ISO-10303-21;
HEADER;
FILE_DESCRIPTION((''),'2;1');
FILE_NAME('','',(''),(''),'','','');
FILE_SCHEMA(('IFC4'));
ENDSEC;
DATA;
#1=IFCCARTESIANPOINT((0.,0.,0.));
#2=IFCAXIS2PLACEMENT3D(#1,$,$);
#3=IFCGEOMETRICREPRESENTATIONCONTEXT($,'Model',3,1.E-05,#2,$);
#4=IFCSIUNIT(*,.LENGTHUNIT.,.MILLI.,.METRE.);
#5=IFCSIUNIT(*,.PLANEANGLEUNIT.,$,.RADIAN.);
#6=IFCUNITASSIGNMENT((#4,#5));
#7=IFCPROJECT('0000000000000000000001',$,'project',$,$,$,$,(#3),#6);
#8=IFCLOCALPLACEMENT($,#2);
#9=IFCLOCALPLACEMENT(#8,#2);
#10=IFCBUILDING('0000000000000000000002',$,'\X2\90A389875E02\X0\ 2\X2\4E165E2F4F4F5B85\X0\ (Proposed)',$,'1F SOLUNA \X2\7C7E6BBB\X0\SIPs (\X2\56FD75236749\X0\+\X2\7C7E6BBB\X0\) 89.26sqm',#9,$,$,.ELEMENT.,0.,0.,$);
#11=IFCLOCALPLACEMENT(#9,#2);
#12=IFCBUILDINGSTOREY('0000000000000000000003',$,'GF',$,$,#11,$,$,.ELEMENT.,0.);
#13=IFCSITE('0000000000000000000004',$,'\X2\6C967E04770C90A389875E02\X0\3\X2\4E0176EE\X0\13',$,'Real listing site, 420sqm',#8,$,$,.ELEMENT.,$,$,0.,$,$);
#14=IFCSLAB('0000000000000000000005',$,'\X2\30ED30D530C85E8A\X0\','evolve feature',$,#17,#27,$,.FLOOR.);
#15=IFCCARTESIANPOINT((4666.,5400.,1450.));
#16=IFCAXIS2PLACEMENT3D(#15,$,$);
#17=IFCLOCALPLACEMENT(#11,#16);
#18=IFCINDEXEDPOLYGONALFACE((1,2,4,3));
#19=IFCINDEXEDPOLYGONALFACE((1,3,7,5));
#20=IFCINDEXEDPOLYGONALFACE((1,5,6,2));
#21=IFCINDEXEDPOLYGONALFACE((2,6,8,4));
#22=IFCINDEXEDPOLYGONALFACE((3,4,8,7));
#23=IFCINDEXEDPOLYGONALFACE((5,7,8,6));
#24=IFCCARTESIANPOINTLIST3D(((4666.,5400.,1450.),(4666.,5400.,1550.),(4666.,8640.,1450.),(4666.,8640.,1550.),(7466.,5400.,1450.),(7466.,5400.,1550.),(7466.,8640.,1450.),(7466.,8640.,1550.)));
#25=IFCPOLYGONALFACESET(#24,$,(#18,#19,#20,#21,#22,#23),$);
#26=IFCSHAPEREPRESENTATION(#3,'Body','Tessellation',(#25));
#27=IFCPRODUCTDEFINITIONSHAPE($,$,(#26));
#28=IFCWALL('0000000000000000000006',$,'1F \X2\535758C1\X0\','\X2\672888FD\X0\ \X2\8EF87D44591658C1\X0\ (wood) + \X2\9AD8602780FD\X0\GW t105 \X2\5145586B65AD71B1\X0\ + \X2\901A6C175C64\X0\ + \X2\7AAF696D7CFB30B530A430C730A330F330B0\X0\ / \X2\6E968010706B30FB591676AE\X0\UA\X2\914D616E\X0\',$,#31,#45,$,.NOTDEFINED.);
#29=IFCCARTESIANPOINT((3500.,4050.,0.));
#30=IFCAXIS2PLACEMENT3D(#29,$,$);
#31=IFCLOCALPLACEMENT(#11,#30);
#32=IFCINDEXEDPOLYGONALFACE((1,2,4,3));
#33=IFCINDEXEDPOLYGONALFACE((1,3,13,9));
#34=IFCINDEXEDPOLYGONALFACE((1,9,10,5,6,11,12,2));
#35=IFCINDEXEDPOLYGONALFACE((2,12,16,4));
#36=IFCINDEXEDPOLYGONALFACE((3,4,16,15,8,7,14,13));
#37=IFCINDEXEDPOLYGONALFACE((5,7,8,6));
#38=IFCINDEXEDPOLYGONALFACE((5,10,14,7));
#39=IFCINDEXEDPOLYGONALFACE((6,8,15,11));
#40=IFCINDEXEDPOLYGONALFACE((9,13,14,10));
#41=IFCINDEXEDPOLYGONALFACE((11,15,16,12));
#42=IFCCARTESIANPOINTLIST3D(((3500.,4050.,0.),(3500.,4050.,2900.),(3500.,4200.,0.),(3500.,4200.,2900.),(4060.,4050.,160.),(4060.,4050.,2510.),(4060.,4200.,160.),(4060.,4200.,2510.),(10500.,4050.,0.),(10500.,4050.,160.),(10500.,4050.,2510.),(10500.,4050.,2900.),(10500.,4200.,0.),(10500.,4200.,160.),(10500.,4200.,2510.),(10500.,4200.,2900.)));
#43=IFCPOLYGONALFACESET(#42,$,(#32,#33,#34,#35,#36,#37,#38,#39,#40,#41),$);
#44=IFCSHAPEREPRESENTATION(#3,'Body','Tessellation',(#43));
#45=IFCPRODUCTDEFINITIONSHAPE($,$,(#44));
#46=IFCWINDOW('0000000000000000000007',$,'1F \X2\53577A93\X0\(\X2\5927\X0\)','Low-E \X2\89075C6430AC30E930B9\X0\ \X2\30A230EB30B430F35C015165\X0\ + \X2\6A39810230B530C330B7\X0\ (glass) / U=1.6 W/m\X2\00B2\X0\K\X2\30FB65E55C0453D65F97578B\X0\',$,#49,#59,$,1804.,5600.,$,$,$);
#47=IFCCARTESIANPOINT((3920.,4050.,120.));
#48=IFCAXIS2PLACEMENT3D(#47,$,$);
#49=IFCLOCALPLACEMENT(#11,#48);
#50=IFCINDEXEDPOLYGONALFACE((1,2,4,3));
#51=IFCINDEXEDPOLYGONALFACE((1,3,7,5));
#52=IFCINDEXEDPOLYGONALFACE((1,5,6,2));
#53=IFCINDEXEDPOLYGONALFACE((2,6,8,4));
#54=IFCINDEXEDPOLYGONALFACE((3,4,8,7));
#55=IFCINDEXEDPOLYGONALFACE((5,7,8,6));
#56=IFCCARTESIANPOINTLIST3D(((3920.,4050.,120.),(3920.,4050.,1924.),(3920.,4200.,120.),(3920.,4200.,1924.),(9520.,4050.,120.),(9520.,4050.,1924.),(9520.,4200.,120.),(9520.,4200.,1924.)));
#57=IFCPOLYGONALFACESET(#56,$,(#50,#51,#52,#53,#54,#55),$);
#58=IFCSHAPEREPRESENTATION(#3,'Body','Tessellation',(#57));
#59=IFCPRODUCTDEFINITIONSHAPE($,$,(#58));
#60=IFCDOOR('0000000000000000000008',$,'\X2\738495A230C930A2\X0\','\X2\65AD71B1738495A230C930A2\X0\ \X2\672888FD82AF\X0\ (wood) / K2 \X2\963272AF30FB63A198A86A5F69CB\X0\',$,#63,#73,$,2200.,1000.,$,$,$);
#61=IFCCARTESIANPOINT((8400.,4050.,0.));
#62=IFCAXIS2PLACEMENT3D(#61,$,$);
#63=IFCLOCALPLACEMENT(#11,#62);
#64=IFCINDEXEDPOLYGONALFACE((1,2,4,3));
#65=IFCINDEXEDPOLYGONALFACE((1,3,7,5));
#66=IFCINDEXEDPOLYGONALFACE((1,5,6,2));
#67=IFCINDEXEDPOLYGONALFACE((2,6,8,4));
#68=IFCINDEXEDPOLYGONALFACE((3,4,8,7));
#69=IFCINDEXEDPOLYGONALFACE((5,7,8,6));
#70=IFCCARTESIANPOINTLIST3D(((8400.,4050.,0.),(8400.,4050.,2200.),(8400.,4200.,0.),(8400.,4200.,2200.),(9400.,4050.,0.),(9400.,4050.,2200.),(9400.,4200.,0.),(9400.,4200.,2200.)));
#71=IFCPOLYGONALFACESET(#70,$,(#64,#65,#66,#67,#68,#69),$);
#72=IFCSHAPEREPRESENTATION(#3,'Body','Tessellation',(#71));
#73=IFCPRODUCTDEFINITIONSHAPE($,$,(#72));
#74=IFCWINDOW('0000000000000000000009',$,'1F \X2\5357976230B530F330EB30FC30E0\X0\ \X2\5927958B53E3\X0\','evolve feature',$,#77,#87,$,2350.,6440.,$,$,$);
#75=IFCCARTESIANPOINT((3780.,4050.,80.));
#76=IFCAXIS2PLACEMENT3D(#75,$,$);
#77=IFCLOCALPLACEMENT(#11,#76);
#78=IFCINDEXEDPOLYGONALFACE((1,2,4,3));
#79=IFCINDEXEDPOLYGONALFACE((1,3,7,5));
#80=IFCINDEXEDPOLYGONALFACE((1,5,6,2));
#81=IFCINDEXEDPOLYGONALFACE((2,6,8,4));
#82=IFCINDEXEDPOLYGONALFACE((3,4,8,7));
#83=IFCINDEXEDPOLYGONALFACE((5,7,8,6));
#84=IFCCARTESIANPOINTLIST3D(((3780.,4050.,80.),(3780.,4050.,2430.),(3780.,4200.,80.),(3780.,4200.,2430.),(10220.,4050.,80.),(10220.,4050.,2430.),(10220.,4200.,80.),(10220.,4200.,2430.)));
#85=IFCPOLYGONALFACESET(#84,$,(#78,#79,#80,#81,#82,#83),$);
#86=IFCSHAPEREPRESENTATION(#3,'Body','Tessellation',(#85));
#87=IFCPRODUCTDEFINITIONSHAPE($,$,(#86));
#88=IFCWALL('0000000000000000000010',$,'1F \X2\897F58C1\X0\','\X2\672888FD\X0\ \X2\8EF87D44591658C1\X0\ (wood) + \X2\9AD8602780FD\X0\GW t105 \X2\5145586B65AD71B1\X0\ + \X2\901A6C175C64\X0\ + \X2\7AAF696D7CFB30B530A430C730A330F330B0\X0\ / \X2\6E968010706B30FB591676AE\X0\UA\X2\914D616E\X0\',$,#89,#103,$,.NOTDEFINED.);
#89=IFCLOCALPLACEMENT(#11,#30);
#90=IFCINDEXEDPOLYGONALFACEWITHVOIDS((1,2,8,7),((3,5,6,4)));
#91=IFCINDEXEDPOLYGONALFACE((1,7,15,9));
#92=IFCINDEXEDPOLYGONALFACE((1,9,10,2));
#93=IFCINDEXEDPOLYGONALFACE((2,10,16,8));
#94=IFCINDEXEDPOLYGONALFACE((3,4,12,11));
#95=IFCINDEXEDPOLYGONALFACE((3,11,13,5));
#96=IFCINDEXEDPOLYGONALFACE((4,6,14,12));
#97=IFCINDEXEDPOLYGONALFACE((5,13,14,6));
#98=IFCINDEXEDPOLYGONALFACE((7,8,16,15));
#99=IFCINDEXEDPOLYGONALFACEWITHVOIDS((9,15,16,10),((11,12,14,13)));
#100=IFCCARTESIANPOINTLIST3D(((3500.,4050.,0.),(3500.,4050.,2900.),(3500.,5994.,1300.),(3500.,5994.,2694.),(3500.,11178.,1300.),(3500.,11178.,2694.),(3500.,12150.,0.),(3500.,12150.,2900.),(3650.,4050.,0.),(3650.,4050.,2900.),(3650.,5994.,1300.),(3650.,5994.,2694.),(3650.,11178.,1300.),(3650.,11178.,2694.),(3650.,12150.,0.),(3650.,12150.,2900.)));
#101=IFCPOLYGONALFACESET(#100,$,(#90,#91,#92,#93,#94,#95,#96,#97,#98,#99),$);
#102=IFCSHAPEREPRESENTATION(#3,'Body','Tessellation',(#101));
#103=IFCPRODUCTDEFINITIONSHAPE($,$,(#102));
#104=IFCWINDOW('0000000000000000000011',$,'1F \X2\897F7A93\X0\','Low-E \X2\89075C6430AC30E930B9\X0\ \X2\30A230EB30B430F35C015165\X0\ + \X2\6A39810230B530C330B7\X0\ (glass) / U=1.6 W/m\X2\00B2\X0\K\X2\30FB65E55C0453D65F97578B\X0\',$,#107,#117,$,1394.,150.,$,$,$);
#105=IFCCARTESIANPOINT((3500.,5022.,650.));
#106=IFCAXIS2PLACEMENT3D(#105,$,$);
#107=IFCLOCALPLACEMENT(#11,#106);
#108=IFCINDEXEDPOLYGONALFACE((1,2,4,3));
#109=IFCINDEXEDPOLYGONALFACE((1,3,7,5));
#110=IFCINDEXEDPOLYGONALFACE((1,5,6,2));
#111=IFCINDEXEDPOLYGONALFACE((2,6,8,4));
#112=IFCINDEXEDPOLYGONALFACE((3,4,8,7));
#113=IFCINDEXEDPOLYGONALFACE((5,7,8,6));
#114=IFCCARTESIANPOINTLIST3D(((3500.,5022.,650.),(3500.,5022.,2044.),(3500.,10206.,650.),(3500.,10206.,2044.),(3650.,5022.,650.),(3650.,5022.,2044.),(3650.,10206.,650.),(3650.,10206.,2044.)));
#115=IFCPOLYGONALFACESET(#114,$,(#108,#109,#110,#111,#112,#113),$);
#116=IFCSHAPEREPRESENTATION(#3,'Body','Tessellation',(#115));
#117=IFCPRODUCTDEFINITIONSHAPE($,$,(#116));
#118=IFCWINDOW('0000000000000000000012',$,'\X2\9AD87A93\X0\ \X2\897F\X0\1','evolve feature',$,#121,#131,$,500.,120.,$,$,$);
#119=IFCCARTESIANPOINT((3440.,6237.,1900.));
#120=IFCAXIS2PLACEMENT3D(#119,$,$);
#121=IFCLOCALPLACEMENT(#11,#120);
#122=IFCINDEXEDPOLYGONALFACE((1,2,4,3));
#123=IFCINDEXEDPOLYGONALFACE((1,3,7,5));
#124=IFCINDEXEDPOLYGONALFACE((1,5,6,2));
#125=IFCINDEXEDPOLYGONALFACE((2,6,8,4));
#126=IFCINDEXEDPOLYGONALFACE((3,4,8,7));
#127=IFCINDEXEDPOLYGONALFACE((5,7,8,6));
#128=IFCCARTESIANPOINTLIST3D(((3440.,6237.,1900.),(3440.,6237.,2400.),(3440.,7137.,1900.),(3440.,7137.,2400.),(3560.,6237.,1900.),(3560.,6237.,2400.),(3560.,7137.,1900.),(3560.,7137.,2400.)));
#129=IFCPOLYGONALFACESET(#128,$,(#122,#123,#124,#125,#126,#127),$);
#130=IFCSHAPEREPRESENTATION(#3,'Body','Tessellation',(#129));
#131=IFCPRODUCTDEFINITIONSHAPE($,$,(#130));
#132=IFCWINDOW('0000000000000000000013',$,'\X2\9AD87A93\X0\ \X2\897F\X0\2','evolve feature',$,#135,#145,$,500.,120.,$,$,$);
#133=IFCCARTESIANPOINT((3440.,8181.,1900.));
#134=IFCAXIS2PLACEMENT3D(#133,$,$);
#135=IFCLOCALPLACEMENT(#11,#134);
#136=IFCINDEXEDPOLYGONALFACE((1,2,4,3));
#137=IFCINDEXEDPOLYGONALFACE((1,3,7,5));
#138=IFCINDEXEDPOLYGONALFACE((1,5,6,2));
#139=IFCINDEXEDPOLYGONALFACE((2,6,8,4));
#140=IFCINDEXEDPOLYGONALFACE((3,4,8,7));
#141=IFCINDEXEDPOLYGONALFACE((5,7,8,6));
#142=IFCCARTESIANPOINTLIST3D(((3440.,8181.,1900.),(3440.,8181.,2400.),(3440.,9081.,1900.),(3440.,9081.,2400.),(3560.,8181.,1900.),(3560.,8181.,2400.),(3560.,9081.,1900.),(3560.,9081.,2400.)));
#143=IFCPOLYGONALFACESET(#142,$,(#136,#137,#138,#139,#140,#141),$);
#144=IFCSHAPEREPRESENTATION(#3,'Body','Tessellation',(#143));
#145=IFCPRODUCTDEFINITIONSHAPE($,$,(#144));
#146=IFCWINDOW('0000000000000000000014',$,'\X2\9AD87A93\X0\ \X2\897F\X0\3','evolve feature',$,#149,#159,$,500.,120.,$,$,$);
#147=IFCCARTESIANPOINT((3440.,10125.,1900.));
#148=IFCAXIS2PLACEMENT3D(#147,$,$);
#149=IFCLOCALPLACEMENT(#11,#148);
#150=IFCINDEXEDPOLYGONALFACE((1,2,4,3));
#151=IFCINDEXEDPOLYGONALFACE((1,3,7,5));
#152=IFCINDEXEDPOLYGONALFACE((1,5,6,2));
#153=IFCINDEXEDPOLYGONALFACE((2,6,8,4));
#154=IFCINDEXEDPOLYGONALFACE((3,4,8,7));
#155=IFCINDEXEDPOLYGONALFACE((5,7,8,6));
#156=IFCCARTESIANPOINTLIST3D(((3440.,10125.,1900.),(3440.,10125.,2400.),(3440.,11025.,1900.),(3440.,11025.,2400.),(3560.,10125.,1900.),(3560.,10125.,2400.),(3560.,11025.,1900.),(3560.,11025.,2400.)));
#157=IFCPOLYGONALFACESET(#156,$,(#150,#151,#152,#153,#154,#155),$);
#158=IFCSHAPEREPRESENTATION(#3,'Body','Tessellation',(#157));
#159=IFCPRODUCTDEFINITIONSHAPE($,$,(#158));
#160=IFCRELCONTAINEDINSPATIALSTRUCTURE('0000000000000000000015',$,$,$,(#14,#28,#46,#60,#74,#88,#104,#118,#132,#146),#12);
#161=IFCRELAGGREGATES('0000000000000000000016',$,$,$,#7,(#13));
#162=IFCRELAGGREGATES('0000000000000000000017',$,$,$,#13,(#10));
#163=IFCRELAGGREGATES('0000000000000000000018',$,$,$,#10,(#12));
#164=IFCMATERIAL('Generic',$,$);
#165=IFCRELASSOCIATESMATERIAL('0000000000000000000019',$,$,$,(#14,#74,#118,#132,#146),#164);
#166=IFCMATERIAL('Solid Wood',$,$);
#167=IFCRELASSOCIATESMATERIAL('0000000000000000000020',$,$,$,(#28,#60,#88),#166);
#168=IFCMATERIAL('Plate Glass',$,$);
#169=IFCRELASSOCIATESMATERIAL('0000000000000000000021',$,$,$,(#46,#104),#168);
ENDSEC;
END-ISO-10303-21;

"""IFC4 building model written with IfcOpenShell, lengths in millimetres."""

from ifc_helpers import new_model, si_unit, frame, frame_2d, origin, place, context, project, spatial, rectangle, extrude, material, element, fill, save


model = new_model("IFC4")

# Units and contexts
model_context = context("Model", 3, precision=1e-05, world=origin())
ifc_project = project(units=[si_unit("LENGTHUNIT", "METRE", prefix="MILLI"), si_unit("PLANEANGLEUNIT", "RADIAN")], contexts=[model_context])

# Site, building, storey
site_placement = place(None, origin())
site = spatial("IfcSite", under=ifc_project, at=site_placement, Name="沖縄県那覇市3丁目13", ObjectType="Real listing site, 420sqm", CompositionType="ELEMENT", RefElevation=0.0)
building_placement = place(site_placement, origin())
building = spatial("IfcBuilding", under=site, at=building_placement, Name="那覇市 2世帯住宅 (Proposed)", ObjectType="1F SOLUNA 籾殻SIPs (国産杉+籾殻) 89.26sqm", CompositionType="ELEMENT", ElevationOfRefHeight=0.0, ElevationOfTerrain=0.0)
storey_placement = place(building_placement, origin())
storey = spatial("IfcBuildingStorey", under=building, at=storey_placement, Name="GF", CompositionType="ELEMENT", Elevation=0.0)

# Slab
ifc_material_1 = material(Name="Solid Wood")
ifc_material_2 = material(Name="Generic")
slab_1_placement = place(storey_placement, frame((4666.0, 5400.0, 1450.0)))
element("IfcSlab", 1, at=slab_1_placement, inside=storey, material=ifc_material_2, Name="ロフト床", Description="evolve feature", PredefinedType="FLOOR", context=model_context, shape_type="SweptSolid", body=[
    extrude(rectangle(XDim=2800.0, YDim=3240.0, at=frame_2d((1400.0, 1620.0))), frame((4666.0, 5400.0, 1450.0)), (0.0, 0.0, 1.0), 100.0),
])

# Wall, openings, windows, door
wall_1_placement = place(storey_placement, frame((3500.0, 4050.0, 0.0)))
wall_1 = element("IfcWall", 2, at=wall_1_placement, inside=storey, material=ifc_material_1, Name="1F 南壁", Description="木製 軸組外壁 (wood) + 高性能GW t105 充填断熱 + 通気層 + 窯業系サイディング / 準耐火・外皮UA配慮", PredefinedType="NOTDEFINED", context=model_context, shape_type="SweptSolid", body=[
    extrude(rectangle(XDim=7000.0, YDim=150.0, at=frame_2d((3500.0, 75.0))), frame((3500.0, 4050.0, 0.0)), (0.0, 0.0, 1.0), 2900.0),
])
opening_1_placement = place(storey_placement, frame((3920.0, 4050.0, 120.0)))
opening_1 = element("IfcOpeningElement", 3, at=opening_1_placement, cuts=wall_1, PredefinedType="NOTDEFINED", context=model_context, shape_type="SweptSolid", body=[
    extrude(rectangle(XDim=5600.0, YDim=150.0, at=frame_2d((2800.0, 75.0))), frame((3920.0, 4050.0, 120.0)), (0.0, 0.0, 1.0), 1804.0),
])
opening_2_placement = place(storey_placement, frame((8400.0, 4050.0, 0.0)))
opening_2 = element("IfcOpeningElement", 4, at=opening_2_placement, cuts=wall_1, PredefinedType="NOTDEFINED", context=model_context, shape_type="SweptSolid", body=[
    extrude(rectangle(XDim=1000.0, YDim=150.0, at=frame_2d((500.0, 75.0))), frame((8400.0, 4050.0, 0.0)), (0.0, 0.0, 1.0), 2200.0),
])
opening_3_placement = place(storey_placement, frame((3780.0, 4050.0, 80.0)))
opening_3 = element("IfcOpeningElement", 5, at=opening_3_placement, cuts=wall_1, PredefinedType="NOTDEFINED", context=model_context, shape_type="SweptSolid", body=[
    extrude(rectangle(XDim=6440.0, YDim=150.0, at=frame_2d((3220.0, 75.0))), frame((3780.0, 4050.0, 80.0)), (0.0, 0.0, 1.0), 2350.0),
])
ifc_material_3 = material(Name="Plate Glass")
window_1_placement = place(storey_placement, frame((3920.0, 4050.0, 120.0)))
window_1 = element("IfcWindow", 6, at=window_1_placement, inside=storey, material=ifc_material_3, Name="1F 南窓(大)", Description="Low-E 複層ガラス アルゴン封入 + 樹脂サッシ (glass) / U=1.6 W/m²K・日射取得型", OverallHeight=1804.0, OverallWidth=5600.0, context=model_context, shape_type="SweptSolid", body=[
    extrude(rectangle(XDim=5600.0, YDim=150.0, at=frame_2d((2800.0, 75.0))), frame((3920.0, 4050.0, 120.0)), (0.0, 0.0, 1.0), 1804.0),
])
fill(opening_1, window_1)
door_placement = place(storey_placement, frame((8400.0, 4050.0, 0.0)))
door = element("IfcDoor", 7, at=door_placement, inside=storey, material=ifc_material_1, Name="玄関ドア", Description="断熱玄関ドア 木製芯 (wood) / K2 防犯・採風機構", OverallHeight=2200.0, OverallWidth=1000.0, context=model_context, shape_type="SweptSolid", body=[
    extrude(rectangle(XDim=1000.0, YDim=150.0, at=frame_2d((500.0, 75.0))), frame((8400.0, 4050.0, 0.0)), (0.0, 0.0, 1.0), 2200.0),
])
fill(opening_2, door)
window_2_placement = place(storey_placement, frame((3780.0, 4050.0, 80.0)))
window_2 = element("IfcWindow", 8, at=window_2_placement, inside=storey, material=ifc_material_2, Name="1F 南面サンルーム 大開口", Description="evolve feature", OverallHeight=2350.0, OverallWidth=6440.0, context=model_context, shape_type="SweptSolid", body=[
    extrude(rectangle(XDim=6440.0, YDim=150.0, at=frame_2d((3220.0, 75.0))), frame((3780.0, 4050.0, 80.0)), (0.0, 0.0, 1.0), 2350.0),
])
fill(opening_3, window_2)

# Wall, openings, windows
wall_2_placement = place(storey_placement, frame((3500.0, 4050.0, 0.0)))
wall_2 = element("IfcWall", 9, at=wall_2_placement, inside=storey, material=ifc_material_1, Name="1F 西壁", Description="木製 軸組外壁 (wood) + 高性能GW t105 充填断熱 + 通気層 + 窯業系サイディング / 準耐火・外皮UA配慮", PredefinedType="NOTDEFINED", context=model_context, shape_type="SweptSolid", body=[
    extrude(rectangle(XDim=150.0, YDim=8100.0, at=frame_2d((75.0, 4050.0))), frame((3500.0, 4050.0, 0.0)), (0.0, 0.0, 1.0), 2900.0),
])
opening_4_placement = place(storey_placement, frame((3500.0, 5022.0, 650.0)))
opening_4 = element("IfcOpeningElement", 10, at=opening_4_placement, cuts=wall_2, PredefinedType="NOTDEFINED", context=model_context, shape_type="SweptSolid", body=[
    extrude(rectangle(XDim=150.0, YDim=5184.0, at=frame_2d((75.0, 2592.0))), frame((3500.0, 5022.0, 650.0)), (0.0, 0.0, 1.0), 1394.0),
])
opening_5_placement = place(storey_placement, frame((3440.0, 6237.0, 1900.0)))
opening_5 = element("IfcOpeningElement", 11, at=opening_5_placement, cuts=wall_2, PredefinedType="NOTDEFINED", context=model_context, shape_type="SweptSolid", body=[
    extrude(rectangle(XDim=120.0, YDim=900.0, at=frame_2d((60.0, 450.0))), frame((3440.0, 6237.0, 1900.0)), (0.0, 0.0, 1.0), 500.0),
])
opening_6_placement = place(storey_placement, frame((3440.0, 8181.0, 1900.0)))
opening_6 = element("IfcOpeningElement", 12, at=opening_6_placement, cuts=wall_2, PredefinedType="NOTDEFINED", context=model_context, shape_type="SweptSolid", body=[
    extrude(rectangle(XDim=120.0, YDim=900.0, at=frame_2d((60.0, 450.0))), frame((3440.0, 8181.0, 1900.0)), (0.0, 0.0, 1.0), 500.0),
])
opening_7_placement = place(storey_placement, frame((3440.0, 10125.0, 1900.0)))
opening_7 = element("IfcOpeningElement", 13, at=opening_7_placement, cuts=wall_2, PredefinedType="NOTDEFINED", context=model_context, shape_type="SweptSolid", body=[
    extrude(rectangle(XDim=120.0, YDim=900.0, at=frame_2d((60.0, 450.0))), frame((3440.0, 10125.0, 1900.0)), (0.0, 0.0, 1.0), 500.0),
])
window_3_placement = place(storey_placement, frame((3500.0, 5022.0, 650.0)))
window_3 = element("IfcWindow", 14, at=window_3_placement, inside=storey, material=ifc_material_3, Name="1F 西窓", Description="Low-E 複層ガラス アルゴン封入 + 樹脂サッシ (glass) / U=1.6 W/m²K・日射取得型", OverallHeight=1394.0, OverallWidth=150.0, context=model_context, shape_type="SweptSolid", body=[
    extrude(rectangle(XDim=150.0, YDim=5184.0, at=frame_2d((75.0, 2592.0))), frame((3500.0, 5022.0, 650.0)), (0.0, 0.0, 1.0), 1394.0),
])
fill(opening_4, window_3)
window_4_placement = place(storey_placement, frame((3440.0, 6237.0, 1900.0)))
window_4 = element("IfcWindow", 15, at=window_4_placement, inside=storey, material=ifc_material_2, Name="高窓 西1", Description="evolve feature", OverallHeight=500.0, OverallWidth=120.0, context=model_context, shape_type="SweptSolid", body=[
    extrude(rectangle(XDim=120.0, YDim=900.0, at=frame_2d((60.0, 450.0))), frame((3440.0, 6237.0, 1900.0)), (0.0, 0.0, 1.0), 500.0),
])
fill(opening_5, window_4)
window_5_placement = place(storey_placement, frame((3440.0, 8181.0, 1900.0)))
window_5 = element("IfcWindow", 16, at=window_5_placement, inside=storey, material=ifc_material_2, Name="高窓 西2", Description="evolve feature", OverallHeight=500.0, OverallWidth=120.0, context=model_context, shape_type="SweptSolid", body=[
    extrude(rectangle(XDim=120.0, YDim=900.0, at=frame_2d((60.0, 450.0))), frame((3440.0, 8181.0, 1900.0)), (0.0, 0.0, 1.0), 500.0),
])
fill(opening_6, window_5)
window_6_placement = place(storey_placement, frame((3440.0, 10125.0, 1900.0)))
window_6 = element("IfcWindow", 17, at=window_6_placement, inside=storey, material=ifc_material_2, Name="高窓 西3", Description="evolve feature", OverallHeight=500.0, OverallWidth=120.0, context=model_context, shape_type="SweptSolid", body=[
    extrude(rectangle(XDim=120.0, YDim=900.0, at=frame_2d((60.0, 450.0))), frame((3440.0, 10125.0, 1900.0)), (0.0, 0.0, 1.0), 500.0),
])
fill(opening_7, window_6)

save(model, "model.ifc")
